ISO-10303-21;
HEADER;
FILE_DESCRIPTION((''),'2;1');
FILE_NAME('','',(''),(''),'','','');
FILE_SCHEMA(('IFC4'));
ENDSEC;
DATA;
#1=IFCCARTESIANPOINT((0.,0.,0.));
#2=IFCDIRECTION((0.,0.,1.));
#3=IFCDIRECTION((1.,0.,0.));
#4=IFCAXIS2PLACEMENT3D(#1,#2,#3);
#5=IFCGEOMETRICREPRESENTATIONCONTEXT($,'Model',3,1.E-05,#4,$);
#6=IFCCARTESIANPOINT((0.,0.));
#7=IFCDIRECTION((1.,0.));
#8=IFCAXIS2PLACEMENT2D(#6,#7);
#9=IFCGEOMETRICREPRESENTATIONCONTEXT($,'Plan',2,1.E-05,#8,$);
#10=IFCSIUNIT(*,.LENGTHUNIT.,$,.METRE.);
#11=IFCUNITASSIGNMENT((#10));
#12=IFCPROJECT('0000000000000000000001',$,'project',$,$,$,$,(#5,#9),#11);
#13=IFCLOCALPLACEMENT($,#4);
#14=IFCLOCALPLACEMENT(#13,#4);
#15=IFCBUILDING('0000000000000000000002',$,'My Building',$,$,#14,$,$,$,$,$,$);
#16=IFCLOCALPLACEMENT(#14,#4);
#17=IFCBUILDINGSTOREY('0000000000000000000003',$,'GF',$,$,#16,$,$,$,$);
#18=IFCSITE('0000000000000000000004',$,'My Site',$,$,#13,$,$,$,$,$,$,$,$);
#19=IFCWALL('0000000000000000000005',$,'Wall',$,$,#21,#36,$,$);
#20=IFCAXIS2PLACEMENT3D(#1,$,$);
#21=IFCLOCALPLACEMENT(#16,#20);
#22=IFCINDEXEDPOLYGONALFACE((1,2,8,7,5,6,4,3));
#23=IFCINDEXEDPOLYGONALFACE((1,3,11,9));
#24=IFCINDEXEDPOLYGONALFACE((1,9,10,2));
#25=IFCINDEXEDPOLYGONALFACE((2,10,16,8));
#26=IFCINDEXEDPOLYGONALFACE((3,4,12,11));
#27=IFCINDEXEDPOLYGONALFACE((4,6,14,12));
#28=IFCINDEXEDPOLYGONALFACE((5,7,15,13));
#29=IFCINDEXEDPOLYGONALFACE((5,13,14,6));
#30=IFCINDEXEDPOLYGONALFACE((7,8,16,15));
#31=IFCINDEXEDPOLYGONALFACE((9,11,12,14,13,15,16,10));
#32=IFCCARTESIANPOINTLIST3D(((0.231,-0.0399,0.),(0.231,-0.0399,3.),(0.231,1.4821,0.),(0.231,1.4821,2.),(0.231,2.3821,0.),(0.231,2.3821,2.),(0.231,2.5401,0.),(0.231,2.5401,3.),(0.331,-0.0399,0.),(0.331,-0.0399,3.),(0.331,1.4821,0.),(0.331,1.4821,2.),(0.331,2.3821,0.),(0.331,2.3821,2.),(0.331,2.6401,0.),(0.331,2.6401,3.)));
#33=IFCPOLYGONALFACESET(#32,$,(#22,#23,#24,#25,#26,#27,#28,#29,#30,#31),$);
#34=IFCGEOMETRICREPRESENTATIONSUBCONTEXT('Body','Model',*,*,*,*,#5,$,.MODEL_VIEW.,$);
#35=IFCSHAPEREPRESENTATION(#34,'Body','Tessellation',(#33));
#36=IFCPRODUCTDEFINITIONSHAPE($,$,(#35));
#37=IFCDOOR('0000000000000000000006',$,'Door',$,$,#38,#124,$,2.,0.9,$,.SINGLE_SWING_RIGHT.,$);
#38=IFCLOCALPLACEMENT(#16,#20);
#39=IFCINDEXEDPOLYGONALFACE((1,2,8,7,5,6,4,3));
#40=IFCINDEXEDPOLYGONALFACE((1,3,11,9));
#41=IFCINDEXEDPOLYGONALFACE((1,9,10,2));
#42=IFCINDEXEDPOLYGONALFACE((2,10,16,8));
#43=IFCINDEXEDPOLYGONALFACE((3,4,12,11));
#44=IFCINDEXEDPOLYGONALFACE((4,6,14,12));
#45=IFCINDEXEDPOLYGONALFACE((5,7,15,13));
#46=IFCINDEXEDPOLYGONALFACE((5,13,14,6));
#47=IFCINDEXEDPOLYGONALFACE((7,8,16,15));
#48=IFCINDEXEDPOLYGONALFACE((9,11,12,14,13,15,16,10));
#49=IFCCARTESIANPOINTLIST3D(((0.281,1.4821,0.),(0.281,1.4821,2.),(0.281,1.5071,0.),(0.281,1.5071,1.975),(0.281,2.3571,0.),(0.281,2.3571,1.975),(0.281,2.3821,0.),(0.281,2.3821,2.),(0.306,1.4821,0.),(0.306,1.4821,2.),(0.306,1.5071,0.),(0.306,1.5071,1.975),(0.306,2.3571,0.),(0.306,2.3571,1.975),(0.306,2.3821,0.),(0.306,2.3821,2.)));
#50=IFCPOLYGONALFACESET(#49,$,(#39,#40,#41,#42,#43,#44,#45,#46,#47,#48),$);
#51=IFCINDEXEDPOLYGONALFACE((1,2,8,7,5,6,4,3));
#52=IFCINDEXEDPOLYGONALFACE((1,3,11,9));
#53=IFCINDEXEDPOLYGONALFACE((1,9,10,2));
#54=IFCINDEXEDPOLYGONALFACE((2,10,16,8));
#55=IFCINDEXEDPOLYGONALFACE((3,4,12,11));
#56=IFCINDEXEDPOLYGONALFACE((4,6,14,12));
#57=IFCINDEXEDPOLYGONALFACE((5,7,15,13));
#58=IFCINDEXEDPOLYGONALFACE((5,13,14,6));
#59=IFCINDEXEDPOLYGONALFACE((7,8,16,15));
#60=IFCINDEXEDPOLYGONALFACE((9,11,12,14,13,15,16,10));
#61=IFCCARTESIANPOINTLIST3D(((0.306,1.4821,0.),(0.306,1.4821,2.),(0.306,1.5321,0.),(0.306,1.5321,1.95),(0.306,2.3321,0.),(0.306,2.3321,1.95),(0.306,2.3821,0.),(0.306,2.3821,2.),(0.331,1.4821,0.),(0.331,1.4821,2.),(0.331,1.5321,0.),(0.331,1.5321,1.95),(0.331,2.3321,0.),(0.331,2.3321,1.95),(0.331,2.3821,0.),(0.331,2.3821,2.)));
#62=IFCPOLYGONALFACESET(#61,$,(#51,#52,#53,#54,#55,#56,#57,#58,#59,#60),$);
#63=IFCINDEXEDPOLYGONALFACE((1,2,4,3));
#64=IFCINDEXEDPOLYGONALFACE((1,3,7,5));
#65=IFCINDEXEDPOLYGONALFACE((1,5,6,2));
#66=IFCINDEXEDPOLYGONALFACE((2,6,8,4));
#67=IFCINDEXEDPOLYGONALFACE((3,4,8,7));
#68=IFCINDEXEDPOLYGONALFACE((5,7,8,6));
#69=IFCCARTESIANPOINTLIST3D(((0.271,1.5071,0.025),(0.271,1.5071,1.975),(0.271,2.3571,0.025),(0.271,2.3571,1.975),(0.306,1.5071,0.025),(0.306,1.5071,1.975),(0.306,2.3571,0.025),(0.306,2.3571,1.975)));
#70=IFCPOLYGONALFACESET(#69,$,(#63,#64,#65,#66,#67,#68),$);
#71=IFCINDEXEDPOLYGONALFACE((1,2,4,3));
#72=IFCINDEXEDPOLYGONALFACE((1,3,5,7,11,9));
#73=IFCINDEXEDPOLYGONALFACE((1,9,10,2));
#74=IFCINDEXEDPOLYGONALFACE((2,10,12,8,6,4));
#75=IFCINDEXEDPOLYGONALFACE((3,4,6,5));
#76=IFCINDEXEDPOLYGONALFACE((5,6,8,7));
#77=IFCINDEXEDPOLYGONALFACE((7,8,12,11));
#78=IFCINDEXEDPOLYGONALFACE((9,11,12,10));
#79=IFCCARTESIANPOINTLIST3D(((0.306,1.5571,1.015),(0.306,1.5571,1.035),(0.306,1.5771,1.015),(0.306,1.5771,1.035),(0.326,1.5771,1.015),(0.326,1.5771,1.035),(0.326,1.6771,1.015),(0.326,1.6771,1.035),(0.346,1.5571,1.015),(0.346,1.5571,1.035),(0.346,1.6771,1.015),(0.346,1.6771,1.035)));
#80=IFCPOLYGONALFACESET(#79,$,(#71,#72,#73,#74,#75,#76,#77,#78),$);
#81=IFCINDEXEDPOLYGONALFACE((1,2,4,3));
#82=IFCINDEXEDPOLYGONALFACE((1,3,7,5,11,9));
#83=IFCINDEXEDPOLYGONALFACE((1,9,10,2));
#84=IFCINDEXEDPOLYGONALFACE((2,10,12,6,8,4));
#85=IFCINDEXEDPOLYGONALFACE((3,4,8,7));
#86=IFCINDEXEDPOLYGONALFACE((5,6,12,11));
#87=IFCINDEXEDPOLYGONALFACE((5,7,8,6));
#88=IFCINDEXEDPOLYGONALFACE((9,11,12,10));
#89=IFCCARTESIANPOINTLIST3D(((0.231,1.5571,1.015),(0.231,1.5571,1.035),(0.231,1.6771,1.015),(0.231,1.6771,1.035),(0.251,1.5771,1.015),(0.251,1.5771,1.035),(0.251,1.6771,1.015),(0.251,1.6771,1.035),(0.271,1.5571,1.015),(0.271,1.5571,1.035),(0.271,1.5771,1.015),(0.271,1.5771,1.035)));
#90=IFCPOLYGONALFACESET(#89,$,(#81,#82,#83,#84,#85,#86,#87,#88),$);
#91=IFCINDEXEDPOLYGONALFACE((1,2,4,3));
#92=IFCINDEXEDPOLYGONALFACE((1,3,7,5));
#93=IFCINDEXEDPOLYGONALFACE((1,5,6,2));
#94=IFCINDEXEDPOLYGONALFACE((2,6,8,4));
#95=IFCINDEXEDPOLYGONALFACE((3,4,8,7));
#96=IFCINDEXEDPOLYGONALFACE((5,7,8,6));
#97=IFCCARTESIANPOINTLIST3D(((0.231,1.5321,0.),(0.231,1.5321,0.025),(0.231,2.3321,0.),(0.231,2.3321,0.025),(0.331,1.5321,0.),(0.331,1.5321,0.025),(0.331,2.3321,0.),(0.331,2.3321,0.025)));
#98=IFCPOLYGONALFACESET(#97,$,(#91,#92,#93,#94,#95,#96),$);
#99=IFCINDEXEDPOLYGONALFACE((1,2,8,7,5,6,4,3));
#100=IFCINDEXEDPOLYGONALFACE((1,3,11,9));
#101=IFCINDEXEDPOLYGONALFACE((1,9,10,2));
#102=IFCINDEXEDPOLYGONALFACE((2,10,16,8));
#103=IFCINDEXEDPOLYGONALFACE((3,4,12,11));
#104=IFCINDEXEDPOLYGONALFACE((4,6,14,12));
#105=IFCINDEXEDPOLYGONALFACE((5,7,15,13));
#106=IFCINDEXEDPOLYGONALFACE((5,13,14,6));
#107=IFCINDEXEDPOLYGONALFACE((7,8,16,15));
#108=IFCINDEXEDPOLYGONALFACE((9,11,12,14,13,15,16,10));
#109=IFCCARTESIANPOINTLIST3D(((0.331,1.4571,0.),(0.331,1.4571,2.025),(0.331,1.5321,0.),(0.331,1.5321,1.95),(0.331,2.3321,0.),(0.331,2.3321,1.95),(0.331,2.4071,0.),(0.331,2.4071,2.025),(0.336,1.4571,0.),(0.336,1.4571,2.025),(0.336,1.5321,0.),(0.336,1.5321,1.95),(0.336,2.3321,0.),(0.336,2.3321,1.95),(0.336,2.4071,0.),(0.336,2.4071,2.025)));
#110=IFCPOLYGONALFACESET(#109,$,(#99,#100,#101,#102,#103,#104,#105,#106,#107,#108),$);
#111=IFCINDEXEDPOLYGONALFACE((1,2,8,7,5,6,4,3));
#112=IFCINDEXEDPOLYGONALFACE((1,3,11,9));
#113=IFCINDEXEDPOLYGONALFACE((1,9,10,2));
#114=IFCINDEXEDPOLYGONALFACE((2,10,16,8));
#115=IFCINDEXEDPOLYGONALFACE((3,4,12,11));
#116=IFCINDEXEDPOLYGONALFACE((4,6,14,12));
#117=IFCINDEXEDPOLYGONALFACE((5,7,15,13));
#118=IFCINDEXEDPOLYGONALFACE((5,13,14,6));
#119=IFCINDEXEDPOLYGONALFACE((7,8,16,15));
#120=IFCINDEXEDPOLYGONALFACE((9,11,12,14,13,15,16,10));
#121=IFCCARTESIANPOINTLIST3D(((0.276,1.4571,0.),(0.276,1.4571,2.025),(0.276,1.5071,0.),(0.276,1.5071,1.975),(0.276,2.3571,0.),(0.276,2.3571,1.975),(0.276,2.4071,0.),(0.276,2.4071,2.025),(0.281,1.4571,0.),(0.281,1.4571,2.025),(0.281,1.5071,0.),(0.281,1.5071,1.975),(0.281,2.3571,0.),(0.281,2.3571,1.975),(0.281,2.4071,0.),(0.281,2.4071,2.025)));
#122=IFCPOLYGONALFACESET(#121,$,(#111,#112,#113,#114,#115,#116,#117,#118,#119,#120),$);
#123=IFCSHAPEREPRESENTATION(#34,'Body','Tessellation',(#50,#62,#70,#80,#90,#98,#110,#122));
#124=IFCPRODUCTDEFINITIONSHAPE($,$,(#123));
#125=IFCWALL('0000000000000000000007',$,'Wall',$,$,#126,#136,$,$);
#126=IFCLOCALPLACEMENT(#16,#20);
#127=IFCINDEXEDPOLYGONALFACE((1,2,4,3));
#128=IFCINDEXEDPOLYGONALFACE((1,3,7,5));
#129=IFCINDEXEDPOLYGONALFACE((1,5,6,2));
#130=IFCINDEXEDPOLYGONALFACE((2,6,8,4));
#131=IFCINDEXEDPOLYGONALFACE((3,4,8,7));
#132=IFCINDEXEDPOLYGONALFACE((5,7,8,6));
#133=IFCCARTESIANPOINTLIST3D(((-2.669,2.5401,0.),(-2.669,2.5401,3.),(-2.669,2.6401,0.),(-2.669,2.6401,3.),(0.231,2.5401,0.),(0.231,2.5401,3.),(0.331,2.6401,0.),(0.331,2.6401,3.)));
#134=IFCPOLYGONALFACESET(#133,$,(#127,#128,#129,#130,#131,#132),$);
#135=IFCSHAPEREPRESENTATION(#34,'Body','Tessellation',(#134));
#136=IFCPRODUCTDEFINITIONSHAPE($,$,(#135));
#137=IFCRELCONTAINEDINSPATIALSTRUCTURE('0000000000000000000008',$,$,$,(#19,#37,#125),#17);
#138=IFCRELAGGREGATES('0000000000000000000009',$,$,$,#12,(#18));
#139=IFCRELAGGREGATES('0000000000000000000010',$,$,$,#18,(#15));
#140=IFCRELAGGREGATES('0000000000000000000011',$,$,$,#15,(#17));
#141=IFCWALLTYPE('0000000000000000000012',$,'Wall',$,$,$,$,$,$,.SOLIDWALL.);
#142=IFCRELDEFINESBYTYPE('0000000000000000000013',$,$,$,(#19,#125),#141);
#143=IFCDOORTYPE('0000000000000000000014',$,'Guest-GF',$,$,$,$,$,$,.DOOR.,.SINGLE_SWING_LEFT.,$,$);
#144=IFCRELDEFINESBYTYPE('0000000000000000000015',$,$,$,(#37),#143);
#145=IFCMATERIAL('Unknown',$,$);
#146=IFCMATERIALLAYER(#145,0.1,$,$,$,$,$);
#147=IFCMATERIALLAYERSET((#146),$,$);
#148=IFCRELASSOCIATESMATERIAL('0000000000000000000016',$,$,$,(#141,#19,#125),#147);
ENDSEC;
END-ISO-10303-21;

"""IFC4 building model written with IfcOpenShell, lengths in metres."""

from ifc_helpers import new_model, entity, si_unit, frame, origin_with_axes, origin_2d_with_axis, place, context, subcontext, project, spatial, line, indexed_curve, outline, extrude, shape, source, transform, mapped, material, layer, layer_set, layer_usage, type_object, type_shapes, element, fill, save


model = new_model("IFC4")

# Units and contexts
model_context = context("Model", 3, precision=1e-05, world=origin_with_axes())
plan_context = context("Plan", 2, precision=1e-05, world=origin_2d_with_axis())
body_context_1 = subcontext(model_context, "Body", "Model", "MODEL_VIEW")
body_context_2 = subcontext(plan_context, "Body", "Plan", "PLAN_VIEW")
ifc_project = project(units=[si_unit("LENGTHUNIT", "METRE")], contexts=[model_context, plan_context])

# Site, building, storey
site_placement = place(None, origin_with_axes())
site = spatial("IfcSite", under=ifc_project, at=site_placement, Name="My Site")
building_placement = place(site_placement, origin_with_axes())
building = spatial("IfcBuilding", under=site, at=building_placement, Name="My Building")
storey_placement = place(building_placement, origin_with_axes())
storey = spatial("IfcBuildingStorey", under=building, at=storey_placement, Name="GF")

# Shared definitions
ifc_material_1 = material(Name="Unknown")

# Shared definitions
ifc_layer_1 = layer(ifc_material_1, 0.1)
ifc_layer_set_1 = layer_set([ifc_layer_1])
wall_type = type_object("IfcWallType", Name="Wall", PredefinedType="SOLIDWALL", material=ifc_layer_set_1)

# Wall, opening, door
ifc_layer_usage_1 = layer_usage(ifc_layer_set_1, "AXIS2", "POSITIVE", 0.0)
wall_1_placement = place(storey_placement, frame((0.331, -0.0399, 0.0), z_axis=(0.0, 0.0, 1.0), x_axis=(0.0, 1.0, 0.0)))
wall_1 = element("IfcWall", 1, at=wall_1_placement, inside=storey, type_object=wall_type, material=ifc_layer_usage_1, Name="Wall", context=body_context_1, shape_type="SweptSolid", body=[
    extrude(outline(indexed_curve([(0.0, 0.0), (0.0, 0.1), (2.58, 0.1), (2.68, 0.0)], segments=[line(1, 2, 3, 4, 1)])), origin_with_axes(), (0.0, 0.0, 1.0), 3.0),
])
shared_shape_1 = source(origin_with_axes(), body_context_1, "Body", "SweptSolid", [
    extrude(outline(indexed_curve([(0.0, 0.0), (0.9, 0.0), (0.9, 2.0), (0.0, 2.0)], segments=[line(1, 2, 3, 4, 1)])), frame((0.0, -0.6, 0.0), z_axis=(0.0, -1.0, 0.0), x_axis=(1.0, 0.0, 0.0)), (0.0, 0.0, -1.0), 1.2),
])
opening_1_placement = place(wall_1_placement, frame((1.522, 0.0, 0.0), z_axis=(0.0, 0.0, 1.0), x_axis=(1.0, 0.0, 0.0)))
opening_1 = element("IfcOpeningElement", 2, at=opening_1_placement, cuts=wall_1, PredefinedType="OPENING", context=body_context_1, shape_type="MappedRepresentation", body=[
    mapped(shared_shape_1, transform((0.0, 0.0, 0.0), x_axis=(1.0, 0.0, 0.0), y_axis=(0.0, 1.0, 0.0), z_axis=(0.0, 0.0, 1.0), scale=1.0)),
])
door_type_1 = type_object("IfcDoorType", Name="Guest-GF", OperationType="SINGLE_SWING_LEFT", PredefinedType="DOOR")
shared_shape_2 = source(origin_with_axes(), body_context_1, "Body", "SweptSolid", [
    extrude(outline(indexed_curve([(0.0, 0.0), (0.0, 2.0), (0.9, 2.0), (0.9, 0.0), (0.875, 0.0), (0.875, 1.975), (0.025, 1.975), (0.025, 0.0)], segments=[line(1, 2, 3, 4, 5, 6, 7, 8, 1)])), frame((0.0, 0.025, 0.0), z_axis=(0.0, -1.0, 0.0), x_axis=(1.0, 0.0, 0.0)), (0.0, 0.0, -1.0), 0.025),
    extrude(outline(indexed_curve([(0.0, 0.0), (0.0, 2.0), (0.9, 2.0), (0.9, 0.0), (0.85, 0.0), (0.85, 1.95), (0.05, 1.95), (0.05, 0.0)], segments=[line(1, 2, 3, 4, 5, 6, 7, 8, 1)])), frame((0.0, 0.0, 0.0), z_axis=(0.0, -1.0, 0.0), x_axis=(1.0, 0.0, 0.0)), (0.0, 0.0, -1.0), 0.025),
    extrude(outline(indexed_curve([(0.0, 0.0), (0.85, 0.0), (0.85, 0.035), (0.0, 0.035)], segments=[line(1, 2, 3, 4, 1)])), frame((0.025, 0.025, 0.025), z_axis=(0.0, 0.0, 1.0), x_axis=(1.0, 0.0, 0.0)), (0.0, 0.0, 1.0), 1.95),
    extrude(outline(indexed_curve([(0.0, 0.0), (0.0, -0.04), (0.12, -0.04), (0.12, -0.02), (0.02, -0.02), (0.02, 0.0)], segments=[line(1, 2, 3, 4, 5, 6, 1)])), frame((0.075, 0.025, 1.015), z_axis=(0.0, 0.0, 1.0), x_axis=(1.0, 0.0, 0.0)), (0.0, 0.0, 1.0), 0.02),
    extrude(outline(indexed_curve([(0.0, 0.0), (0.0, 0.04), (0.12, 0.04), (0.12, 0.02), (0.02, 0.02), (0.02, 0.0)], segments=[line(1, 2, 3, 4, 5, 6, 1)])), frame((0.075, 0.06, 1.015), z_axis=(0.0, 0.0, 1.0), x_axis=(1.0, 0.0, 0.0)), (0.0, 0.0, 1.0), 0.02),
    extrude(outline(indexed_curve([(0.0, 0.0), (0.8, 0.0), (0.8, 0.1), (0.0, 0.1)], segments=[line(1, 2, 3, 4, 1)])), frame((0.05, 0.0, 0.0), z_axis=(0.0, 0.0, 1.0), x_axis=(1.0, 0.0, 0.0)), (0.0, 0.0, 1.0), 0.025),
    extrude(outline(indexed_curve([(0.0, 0.0), (0.0, 2.025), (0.95, 2.025), (0.95, 0.0), (0.875, 0.0), (0.875, 1.95), (0.075, 1.95), (0.075, 0.0)], segments=[line(1, 2, 3, 4, 5, 6, 7, 8, 1)])), frame((-0.025, -0.005, 0.0), z_axis=(0.0, -1.0, 0.0), x_axis=(1.0, 0.0, 0.0)), (0.0, 0.0, -1.0), 0.005),
    extrude(outline(indexed_curve([(0.0, 0.0), (0.0, 2.025), (0.95, 2.025), (0.95, 0.0), (0.9, 0.0), (0.9, 1.975), (0.05, 1.975), (0.05, 0.0)], segments=[line(1, 2, 3, 4, 5, 6, 7, 8, 1)])), frame((-0.025, 0.05, 0.0), z_axis=(0.0, -1.0, 0.0), x_axis=(1.0, 0.0, 0.0)), (0.0, 0.0, -1.0), 0.005),
])
shared_shape_3 = source(origin_with_axes(), body_context_2, "Body", "Curve2D", [
    entity("IfcIndexedPolyCurve", entity("IfcCartesianPointList2D", [[0.0, 0.0], [0.0, 0.05], [0.025, 0.05], [0.025, 0.025], [0.05, 0.025], [0.05, 0.0]]), [entity("IfcLineIndex", [1, 2, 3, 4, 5, 6, 1])]),
    entity("IfcIndexedPolyCurve", entity("IfcCartesianPointList2D", [[0.9, 0.0], [0.9, 0.05], [0.875, 0.05], [0.875, 0.025], [0.85, 0.025], [0.85, 0.0]]), [entity("IfcLineIndex", [1, 2, 3, 4, 5, 6, 1])]),
    entity("IfcTrimmedCurve", entity("IfcEllipse", entity("IfcAxis2Placement2D", entity("IfcCartesianPoint", [0.84, 0.05]), entity("IfcDirection", [1.0, 0.0])), 0.815, 0.85), [entity("IfcCartesianPoint", [0.84, 0.9])], [entity("IfcCartesianPoint", [0.025, 0.05])], True, "CARTESIAN"),
    entity("IfcIndexedPolyCurve", entity("IfcCartesianPointList2D", [[0.875, 0.05], [0.84, 0.05], [0.84, 0.9], [0.875, 0.9]]), [entity("IfcLineIndex", [1, 2, 3, 4, 1])]),
])
type_shapes(door_type_1, [shared_shape_2, shared_shape_3])
door_1_placement = place(opening_1_placement, frame((0.0, 0.0, 0.0), z_axis=(0.0, 0.0, 1.0), x_axis=(1.0, 0.0, 0.0)))
door_1 = element("IfcDoor", 3, at=door_1_placement, inside=storey, type_object=door_type_1, Name="Door", OperationType="SINGLE_SWING_RIGHT", OverallHeight=2.0, OverallWidth=0.9, shapes=[
    shape(body_context_1, "Body", "MappedRepresentation", [mapped(shared_shape_2, transform((0.0, 0.0, 0.0), x_axis=(1.0, 0.0, 0.0), y_axis=(0.0, 1.0, 0.0), z_axis=(0.0, 0.0, 1.0), scale=1.0))]),
    shape(body_context_2, "Body", "MappedRepresentation", [mapped(shared_shape_3, transform((0.0, 0.0, 0.0), x_axis=(1.0, 0.0, 0.0), y_axis=(0.0, 1.0, 0.0), z_axis=(0.0, 0.0, 1.0), scale=1.0))]),
])
fill(opening_1, door_1)

# Wall
ifc_layer_usage_2 = layer_usage(ifc_layer_set_1, "AXIS2", "POSITIVE", 0.0)
wall_2_placement = place(storey_placement, frame((0.331, 2.6401, 0.0), z_axis=(0.0, 0.0, 1.0), x_axis=(-1.0, 0.0, 0.0)))
element("IfcWall", 4, at=wall_2_placement, inside=storey, type_object=wall_type, material=ifc_layer_usage_2, Name="Wall", context=body_context_1, shape_type="SweptSolid", body=[
    extrude(outline(indexed_curve([(0.0, 0.0), (0.1, 0.1), (3.0, 0.1), (3.0, 0.0)], segments=[line(1, 2, 3, 4, 1)])), origin_with_axes(), (0.0, 0.0, 1.0), 3.0),
])

save(model, "model.ifc")
